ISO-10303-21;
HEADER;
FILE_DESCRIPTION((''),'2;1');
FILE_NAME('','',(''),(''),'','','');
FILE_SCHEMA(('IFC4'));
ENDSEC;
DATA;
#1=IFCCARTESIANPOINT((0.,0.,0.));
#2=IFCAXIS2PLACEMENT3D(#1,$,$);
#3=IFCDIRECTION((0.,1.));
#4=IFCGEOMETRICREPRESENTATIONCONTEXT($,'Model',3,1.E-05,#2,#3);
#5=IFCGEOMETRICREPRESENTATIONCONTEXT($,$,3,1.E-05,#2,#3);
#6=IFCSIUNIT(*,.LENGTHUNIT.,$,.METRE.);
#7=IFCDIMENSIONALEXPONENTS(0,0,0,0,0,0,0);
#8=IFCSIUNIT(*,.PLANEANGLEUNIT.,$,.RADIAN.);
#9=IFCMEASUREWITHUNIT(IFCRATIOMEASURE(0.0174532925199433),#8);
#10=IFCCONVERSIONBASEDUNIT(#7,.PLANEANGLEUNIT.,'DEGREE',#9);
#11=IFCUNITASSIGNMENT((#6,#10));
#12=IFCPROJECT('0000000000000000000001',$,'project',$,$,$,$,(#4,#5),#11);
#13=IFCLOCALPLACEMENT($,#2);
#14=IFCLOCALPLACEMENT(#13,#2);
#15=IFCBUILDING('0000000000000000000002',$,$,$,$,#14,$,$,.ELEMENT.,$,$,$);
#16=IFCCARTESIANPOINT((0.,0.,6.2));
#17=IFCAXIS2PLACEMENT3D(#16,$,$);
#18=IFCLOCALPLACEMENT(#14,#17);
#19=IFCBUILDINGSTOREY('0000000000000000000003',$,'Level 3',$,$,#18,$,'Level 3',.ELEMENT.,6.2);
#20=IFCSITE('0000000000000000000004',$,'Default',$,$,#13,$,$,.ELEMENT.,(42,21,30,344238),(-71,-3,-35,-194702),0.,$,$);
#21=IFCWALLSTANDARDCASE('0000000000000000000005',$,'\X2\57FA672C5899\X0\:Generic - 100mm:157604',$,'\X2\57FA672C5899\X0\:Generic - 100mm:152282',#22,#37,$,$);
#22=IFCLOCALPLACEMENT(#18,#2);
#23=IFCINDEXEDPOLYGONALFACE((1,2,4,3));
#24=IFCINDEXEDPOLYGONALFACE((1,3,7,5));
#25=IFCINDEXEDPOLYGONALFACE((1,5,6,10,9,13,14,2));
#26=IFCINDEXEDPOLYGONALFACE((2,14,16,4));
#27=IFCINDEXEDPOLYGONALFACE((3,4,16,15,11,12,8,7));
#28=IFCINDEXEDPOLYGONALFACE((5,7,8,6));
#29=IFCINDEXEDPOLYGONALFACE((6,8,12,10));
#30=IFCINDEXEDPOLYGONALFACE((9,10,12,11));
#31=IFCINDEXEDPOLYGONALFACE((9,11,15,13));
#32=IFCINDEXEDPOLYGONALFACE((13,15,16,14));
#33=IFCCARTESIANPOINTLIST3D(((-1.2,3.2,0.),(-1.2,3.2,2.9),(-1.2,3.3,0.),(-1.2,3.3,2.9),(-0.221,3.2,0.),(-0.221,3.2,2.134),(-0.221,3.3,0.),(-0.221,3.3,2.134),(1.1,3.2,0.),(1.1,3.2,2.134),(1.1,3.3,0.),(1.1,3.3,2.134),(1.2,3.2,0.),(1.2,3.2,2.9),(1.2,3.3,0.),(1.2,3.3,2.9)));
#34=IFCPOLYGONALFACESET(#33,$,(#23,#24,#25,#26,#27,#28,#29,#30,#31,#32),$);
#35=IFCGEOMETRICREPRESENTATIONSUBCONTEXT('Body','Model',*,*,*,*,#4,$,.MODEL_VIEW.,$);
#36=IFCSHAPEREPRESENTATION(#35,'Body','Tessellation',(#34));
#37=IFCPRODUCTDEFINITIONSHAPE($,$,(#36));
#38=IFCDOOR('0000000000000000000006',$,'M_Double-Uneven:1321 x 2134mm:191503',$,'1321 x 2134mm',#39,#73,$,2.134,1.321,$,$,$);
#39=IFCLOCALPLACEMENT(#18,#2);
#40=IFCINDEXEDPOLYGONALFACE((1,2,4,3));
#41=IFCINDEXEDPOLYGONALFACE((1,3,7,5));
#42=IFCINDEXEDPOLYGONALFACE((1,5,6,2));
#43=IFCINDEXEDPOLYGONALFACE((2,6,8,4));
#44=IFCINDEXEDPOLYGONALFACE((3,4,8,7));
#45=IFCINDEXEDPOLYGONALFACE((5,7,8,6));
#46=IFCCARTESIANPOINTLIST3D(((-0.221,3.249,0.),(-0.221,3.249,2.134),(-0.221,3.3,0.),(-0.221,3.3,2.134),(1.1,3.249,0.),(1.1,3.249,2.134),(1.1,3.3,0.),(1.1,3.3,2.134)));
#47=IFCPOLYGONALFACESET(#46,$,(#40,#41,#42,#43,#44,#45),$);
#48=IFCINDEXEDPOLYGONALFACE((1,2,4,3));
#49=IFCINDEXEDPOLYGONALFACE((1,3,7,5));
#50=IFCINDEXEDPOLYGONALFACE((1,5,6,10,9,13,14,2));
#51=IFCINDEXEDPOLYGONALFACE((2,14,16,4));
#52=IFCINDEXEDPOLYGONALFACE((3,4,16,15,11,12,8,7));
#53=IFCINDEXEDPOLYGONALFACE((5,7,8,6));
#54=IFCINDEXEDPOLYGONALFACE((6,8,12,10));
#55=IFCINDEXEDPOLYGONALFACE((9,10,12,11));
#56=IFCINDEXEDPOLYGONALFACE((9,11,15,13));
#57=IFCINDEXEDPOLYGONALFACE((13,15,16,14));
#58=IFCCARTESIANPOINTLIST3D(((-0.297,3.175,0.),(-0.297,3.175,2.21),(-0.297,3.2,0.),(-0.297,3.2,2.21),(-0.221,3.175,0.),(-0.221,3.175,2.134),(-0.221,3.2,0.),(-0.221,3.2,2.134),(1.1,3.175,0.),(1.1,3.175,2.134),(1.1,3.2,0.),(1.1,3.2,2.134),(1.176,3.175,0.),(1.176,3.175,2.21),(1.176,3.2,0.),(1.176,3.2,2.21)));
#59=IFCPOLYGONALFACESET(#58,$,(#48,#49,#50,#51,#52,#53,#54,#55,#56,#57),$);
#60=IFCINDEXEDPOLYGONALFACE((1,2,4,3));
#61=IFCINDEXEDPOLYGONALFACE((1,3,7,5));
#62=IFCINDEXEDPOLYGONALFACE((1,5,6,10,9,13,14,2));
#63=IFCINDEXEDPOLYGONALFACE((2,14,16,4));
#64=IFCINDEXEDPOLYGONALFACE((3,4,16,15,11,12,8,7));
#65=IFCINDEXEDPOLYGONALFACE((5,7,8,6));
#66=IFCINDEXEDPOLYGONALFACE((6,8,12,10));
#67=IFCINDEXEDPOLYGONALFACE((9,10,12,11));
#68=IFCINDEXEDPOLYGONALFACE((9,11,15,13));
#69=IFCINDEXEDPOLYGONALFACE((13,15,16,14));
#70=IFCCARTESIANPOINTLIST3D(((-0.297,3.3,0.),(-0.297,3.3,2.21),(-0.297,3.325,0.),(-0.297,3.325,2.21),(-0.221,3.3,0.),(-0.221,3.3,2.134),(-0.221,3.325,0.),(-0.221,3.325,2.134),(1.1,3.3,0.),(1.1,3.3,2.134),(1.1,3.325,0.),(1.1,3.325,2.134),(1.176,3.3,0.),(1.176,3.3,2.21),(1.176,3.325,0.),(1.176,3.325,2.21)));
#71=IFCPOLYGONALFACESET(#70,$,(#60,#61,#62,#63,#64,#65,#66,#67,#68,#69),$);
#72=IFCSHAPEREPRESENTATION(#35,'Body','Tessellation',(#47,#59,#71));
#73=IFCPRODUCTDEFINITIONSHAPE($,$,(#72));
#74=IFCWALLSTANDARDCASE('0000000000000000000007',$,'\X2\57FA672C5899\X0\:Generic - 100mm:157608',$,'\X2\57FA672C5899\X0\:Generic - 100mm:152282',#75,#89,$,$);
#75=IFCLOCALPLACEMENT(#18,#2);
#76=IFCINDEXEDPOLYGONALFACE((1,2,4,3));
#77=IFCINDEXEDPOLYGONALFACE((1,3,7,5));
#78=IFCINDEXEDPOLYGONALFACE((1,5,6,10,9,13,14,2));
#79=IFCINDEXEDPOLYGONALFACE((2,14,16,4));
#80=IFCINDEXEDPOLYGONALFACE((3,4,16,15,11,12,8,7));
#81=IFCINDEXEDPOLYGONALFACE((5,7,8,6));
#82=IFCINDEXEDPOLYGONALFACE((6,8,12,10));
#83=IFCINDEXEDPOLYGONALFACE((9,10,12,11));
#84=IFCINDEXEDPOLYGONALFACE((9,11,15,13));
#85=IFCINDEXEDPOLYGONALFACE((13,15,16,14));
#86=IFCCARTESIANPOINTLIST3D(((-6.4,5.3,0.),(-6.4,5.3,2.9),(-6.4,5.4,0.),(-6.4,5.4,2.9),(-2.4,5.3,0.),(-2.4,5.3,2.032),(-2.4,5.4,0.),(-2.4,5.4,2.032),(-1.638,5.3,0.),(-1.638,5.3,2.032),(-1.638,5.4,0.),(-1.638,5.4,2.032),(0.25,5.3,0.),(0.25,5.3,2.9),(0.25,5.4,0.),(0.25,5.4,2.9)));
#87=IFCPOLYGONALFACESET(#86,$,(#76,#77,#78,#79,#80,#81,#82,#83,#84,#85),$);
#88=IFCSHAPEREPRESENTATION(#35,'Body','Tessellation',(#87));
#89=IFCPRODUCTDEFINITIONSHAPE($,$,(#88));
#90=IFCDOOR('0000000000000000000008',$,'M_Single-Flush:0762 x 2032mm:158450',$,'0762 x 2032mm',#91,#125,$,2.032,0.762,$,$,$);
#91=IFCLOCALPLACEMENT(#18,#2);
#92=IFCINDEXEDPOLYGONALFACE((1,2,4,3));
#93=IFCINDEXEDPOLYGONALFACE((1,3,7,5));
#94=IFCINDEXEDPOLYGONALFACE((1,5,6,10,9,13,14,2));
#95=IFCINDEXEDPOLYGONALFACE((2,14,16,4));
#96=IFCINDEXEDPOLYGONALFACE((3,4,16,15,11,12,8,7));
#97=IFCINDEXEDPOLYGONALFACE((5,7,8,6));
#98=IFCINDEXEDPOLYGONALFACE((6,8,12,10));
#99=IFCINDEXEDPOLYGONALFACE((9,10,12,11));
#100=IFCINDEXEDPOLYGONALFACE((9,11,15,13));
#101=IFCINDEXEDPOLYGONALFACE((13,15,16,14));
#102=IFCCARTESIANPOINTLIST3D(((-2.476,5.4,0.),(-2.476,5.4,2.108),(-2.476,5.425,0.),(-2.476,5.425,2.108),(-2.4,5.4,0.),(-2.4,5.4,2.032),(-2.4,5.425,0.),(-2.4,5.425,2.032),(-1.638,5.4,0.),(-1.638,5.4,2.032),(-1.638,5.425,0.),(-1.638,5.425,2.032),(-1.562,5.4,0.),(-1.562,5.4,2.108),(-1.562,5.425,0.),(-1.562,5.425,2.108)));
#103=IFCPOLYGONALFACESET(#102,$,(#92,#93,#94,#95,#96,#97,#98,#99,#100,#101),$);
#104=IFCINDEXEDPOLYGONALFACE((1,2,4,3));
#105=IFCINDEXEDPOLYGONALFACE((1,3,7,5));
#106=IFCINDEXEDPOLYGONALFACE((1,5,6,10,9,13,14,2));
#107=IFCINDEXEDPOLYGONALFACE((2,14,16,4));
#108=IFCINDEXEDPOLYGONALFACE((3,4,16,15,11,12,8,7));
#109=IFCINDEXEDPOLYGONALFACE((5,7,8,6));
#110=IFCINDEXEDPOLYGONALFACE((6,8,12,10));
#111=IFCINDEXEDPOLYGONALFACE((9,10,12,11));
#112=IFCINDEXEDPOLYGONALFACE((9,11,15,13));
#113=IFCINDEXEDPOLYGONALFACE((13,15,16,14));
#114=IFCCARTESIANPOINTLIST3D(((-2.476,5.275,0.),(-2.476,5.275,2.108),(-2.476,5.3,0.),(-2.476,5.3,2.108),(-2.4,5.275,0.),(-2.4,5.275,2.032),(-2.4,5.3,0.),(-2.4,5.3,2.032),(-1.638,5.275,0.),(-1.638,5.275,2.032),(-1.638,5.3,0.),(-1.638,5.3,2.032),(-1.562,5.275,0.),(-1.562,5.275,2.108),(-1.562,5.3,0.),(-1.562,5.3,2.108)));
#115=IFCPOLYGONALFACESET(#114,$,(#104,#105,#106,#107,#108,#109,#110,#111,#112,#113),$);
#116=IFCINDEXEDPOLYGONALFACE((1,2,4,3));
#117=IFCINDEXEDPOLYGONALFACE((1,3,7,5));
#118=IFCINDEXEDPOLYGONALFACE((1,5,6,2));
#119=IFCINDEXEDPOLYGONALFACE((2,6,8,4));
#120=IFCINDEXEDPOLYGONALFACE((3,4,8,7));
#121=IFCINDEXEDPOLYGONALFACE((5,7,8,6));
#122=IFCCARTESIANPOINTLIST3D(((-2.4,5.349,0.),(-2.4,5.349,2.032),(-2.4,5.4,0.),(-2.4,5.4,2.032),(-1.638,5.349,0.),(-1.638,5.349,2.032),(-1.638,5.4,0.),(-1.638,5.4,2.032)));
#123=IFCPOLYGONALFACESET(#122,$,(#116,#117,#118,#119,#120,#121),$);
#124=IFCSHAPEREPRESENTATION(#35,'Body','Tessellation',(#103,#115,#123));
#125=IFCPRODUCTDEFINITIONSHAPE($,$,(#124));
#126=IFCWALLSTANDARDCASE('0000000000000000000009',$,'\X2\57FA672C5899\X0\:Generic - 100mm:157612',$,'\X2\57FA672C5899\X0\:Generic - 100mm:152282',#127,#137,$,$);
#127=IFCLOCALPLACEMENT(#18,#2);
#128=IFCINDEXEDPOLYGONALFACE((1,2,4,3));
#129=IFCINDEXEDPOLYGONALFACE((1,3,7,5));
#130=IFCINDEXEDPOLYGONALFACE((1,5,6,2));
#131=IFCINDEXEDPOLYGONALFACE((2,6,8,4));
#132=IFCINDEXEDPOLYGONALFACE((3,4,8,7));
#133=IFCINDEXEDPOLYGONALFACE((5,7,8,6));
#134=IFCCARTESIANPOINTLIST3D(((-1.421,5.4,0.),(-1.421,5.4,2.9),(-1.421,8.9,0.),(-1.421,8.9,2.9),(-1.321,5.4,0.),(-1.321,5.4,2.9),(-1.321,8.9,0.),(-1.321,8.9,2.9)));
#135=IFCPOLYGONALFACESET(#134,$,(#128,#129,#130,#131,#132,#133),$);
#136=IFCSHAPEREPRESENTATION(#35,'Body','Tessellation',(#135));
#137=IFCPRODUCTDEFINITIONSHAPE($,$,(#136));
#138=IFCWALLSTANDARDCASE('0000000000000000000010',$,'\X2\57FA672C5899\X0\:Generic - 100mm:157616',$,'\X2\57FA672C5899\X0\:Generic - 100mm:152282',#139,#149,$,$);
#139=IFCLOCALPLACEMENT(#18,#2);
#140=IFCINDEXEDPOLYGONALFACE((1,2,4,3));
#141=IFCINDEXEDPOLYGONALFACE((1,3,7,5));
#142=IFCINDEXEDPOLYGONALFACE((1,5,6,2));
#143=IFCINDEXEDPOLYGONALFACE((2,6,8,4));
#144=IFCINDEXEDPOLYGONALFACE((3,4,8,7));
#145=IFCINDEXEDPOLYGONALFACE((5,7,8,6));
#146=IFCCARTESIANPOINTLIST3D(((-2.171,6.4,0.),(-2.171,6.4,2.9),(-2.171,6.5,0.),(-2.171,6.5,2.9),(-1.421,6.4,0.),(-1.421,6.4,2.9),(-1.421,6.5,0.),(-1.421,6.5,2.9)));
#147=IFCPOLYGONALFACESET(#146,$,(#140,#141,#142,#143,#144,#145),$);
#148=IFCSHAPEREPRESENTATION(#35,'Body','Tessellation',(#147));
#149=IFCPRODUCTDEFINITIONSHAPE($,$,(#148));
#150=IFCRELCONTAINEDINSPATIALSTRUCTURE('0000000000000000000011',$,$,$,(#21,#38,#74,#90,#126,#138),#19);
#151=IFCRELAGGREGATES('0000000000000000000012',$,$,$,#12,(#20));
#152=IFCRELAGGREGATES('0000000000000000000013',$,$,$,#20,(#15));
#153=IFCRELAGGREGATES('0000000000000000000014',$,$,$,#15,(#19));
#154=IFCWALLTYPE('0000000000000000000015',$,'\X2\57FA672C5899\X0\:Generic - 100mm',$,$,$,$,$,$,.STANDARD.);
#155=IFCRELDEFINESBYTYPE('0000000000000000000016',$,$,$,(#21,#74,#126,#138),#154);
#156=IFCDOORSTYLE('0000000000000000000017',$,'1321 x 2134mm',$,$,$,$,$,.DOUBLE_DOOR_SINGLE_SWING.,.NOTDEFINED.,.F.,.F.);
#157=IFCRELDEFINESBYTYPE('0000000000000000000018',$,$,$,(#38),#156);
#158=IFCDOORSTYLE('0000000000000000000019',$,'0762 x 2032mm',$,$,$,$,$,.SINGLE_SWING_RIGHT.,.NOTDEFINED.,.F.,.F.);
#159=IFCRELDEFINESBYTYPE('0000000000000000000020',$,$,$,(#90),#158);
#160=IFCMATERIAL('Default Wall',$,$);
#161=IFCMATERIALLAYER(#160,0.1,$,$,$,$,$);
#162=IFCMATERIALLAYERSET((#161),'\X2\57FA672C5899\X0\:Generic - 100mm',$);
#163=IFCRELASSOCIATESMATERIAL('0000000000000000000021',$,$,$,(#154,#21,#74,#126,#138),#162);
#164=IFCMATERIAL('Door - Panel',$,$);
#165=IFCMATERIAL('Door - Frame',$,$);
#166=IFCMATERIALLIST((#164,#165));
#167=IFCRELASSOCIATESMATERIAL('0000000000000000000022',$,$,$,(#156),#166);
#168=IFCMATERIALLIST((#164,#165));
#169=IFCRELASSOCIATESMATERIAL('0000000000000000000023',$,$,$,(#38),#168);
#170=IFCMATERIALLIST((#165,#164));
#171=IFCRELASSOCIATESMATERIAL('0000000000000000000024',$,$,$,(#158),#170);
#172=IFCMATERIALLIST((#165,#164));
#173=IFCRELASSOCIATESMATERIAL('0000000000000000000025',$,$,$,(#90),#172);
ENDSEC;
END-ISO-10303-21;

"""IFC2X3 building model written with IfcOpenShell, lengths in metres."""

from ifc_helpers import new_model, entity, si_unit, converted_unit, direction, frame, frame_2d, origin, origin_2d_with_axis, place, context, subcontext, project, spatial, polyline, rectangle, outline, extrude, clip, bounded_halfspace, source, transform, mapped, material, material_list, layer, layer_set, layer_usage, type_object, type_shapes, element, fill, save


model = new_model("IFC2X3")

# Units and contexts
model_context = context("Model", 3, precision=1e-05, world=origin(), true_north=direction((0.0, 1.0)))
context_of_model = context(None, 3, precision=1e-05, world=origin(), true_north=direction((0.0, 1.0)))
body_context = subcontext(model_context, "Body", "Model", "MODEL_VIEW")
ifc_project = project(units=[si_unit("LENGTHUNIT", "METRE"), converted_unit("PLANEANGLEUNIT", "DEGREE", entity("IfcRatioMeasure", 0.0174532925199433), si_unit("PLANEANGLEUNIT", "RADIAN"), dimensions=[0, 0, 0, 0, 0, 0, 0])], contexts=[model_context, context_of_model])

# Site, building, storey
site_placement = place(None, origin())
site = spatial("IfcSite", under=ifc_project, at=site_placement, Name="Default", CompositionType="ELEMENT", RefLatitude=(42, 21, 30, 344238), RefLongitude=(-71, -3, -35, -194702), RefElevation=0.0)
building_placement = place(site_placement, origin())
building = spatial("IfcBuilding", under=site, at=building_placement, CompositionType="ELEMENT")
storey_placement = place(building_placement, frame((0.0, 0.0, 6.2)))
storey = spatial("IfcBuildingStorey", under=building, at=storey_placement, Name="Level 3", LongName="Level 3", CompositionType="ELEMENT", Elevation=6.2)

# Shared definitions
ifc_material_1 = material(Name="Default Wall")

# Shared definitions
ifc_material_2 = material(Name="Door - Panel")
ifc_material_3 = material(Name="Door - Frame")

# Shared definitions
ifc_layer_1 = layer(ifc_material_1, 0.1)
ifc_layer_set_1 = layer_set([ifc_layer_1], Name="基本墙:Generic - 100mm")
wall_type_1 = type_object("IfcWallType", Name="基本墙:Generic - 100mm", PredefinedType="STANDARD", material=ifc_layer_set_1)

# Walls, openings, doors
ifc_layer_usage_1 = layer_usage(ifc_layer_set_1, "AXIS2", "NEGATIVE", 0.05)
wall_1_placement = place(storey_placement, frame((-1.2, 3.25, 0.0)))
wall_1 = element("IfcWallStandardCase", 1, at=wall_1_placement, inside=storey, type_object=wall_type_1, material=ifc_layer_usage_1, Name="基本墙:Generic - 100mm:157604", ObjectType="基本墙:Generic - 100mm:152282", context=body_context, shape_type="Clipping", body=[
    clip(extrude(rectangle(XDim=2.4, YDim=0.1, at=frame_2d((1.2, 0.0), x_axis=(-1.0, 0.0))), origin(), (0.0, 0.0, 1.0), 3.2), bounded_halfspace(frame((0.0, -0.05, 2.9), z_axis=(0.0, 0.0, -1.0), x_axis=(0.0, -1.0, 0.0)), True, frame((0.0, -0.05, 2.9), z_axis=(0.0, 0.0, -1.0), x_axis=(0.0, -1.0, 0.0)), polyline([(0.0, 0.0), (-0.1, 0.0), (-0.1, -2.4), (0.0, -2.4), (0.0, 0.0)]))),
])
opening_1_placement = place(wall_1_placement, frame((0.979, -0.05, 0.0)))
opening_1 = element("IfcOpeningElement", 2, at=opening_1_placement, cuts=wall_1, ObjectType="Opening", context=body_context, shape_type="SweptSolid", body=[
    extrude(rectangle(XDim=2.134, YDim=1.321, at=frame_2d((1.067, 0.6605), x_axis=(1.0, 0.0))), frame((0.0, 0.0, 0.0), z_axis=(0.0, 1.0, 0.0), x_axis=(0.0, 0.0, 1.0)), (0.0, 0.0, 1.0), 0.1),
])
ifc_material_list_1 = material_list([ifc_material_2, ifc_material_3])
ifc_material_list_2 = material_list([ifc_material_2, ifc_material_3])
door_style_1 = type_object("IfcDoorStyle", Name="1321 x 2134mm", ConstructionType="NOTDEFINED", OperationType="DOUBLE_DOOR_SINGLE_SWING", ParameterTakesPrecedence=False, Sizeable=False, material=ifc_material_list_2)
shared_shape_1 = source(origin(), body_context, "Body", "SweptSolid", [
    extrude(rectangle(XDim=0.051, YDim=1.321, at=origin_2d_with_axis()), frame((1.7775, 0.0745, 0.0), z_axis=(0.0, 0.0, 1.0), x_axis=(0.0, -1.0, 0.0)), (0.0, 0.0, 1.0), 2.134),
    extrude(outline(polyline([(-1.048, 0.6605), (1.086, 0.6605), (1.086, 0.7365), (-1.124, 0.7365), (-1.124, -0.7365), (1.086, -0.7365), (1.086, -0.6605), (-1.048, -0.6605), (-1.048, 0.6605)])), frame((1.7775, 0.0, 1.086), z_axis=(0.0, -1.0, 0.0), x_axis=(0.0, 0.0, -1.0)), (0.0, 0.0, 1.0), 0.025),
    extrude(outline(polyline([(-1.048, 0.6605), (1.086, 0.6605), (1.086, 0.7365), (-1.124, 0.7365), (-1.124, -0.7365), (1.086, -0.7365), (1.086, -0.6605), (-1.048, -0.6605), (-1.048, 0.6605)])), frame((1.7775, 0.125, 1.086), z_axis=(0.0, -1.0, 0.0), x_axis=(0.0, 0.0, -1.0)), (0.0, 0.0, 1.0), 0.025),
])
type_shapes(door_style_1, [shared_shape_1])
door_1_placement = place(opening_1_placement, frame((-1.117, 0.0, 0.0)))
door_1 = element("IfcDoor", 3, at=door_1_placement, inside=storey, type_object=door_style_1, material=ifc_material_list_1, Name="M_Double-Uneven:1321 x 2134mm:191503", ObjectType="1321 x 2134mm", OverallHeight=2.134, OverallWidth=1.321, context=body_context, shape_type="MappedRepresentation", body=[
    mapped(shared_shape_1, transform((0.0, 0.0, 0.0), scale=1.0)),
])
fill(opening_1, door_1)
ifc_layer_usage_2 = layer_usage(ifc_layer_set_1, "AXIS2", "NEGATIVE", 0.05)
wall_2_placement = place(storey_placement, frame((-6.4, 5.35, 0.0)))
wall_2 = element("IfcWallStandardCase", 4, at=wall_2_placement, inside=storey, type_object=wall_type_1, material=ifc_layer_usage_2, Name="基本墙:Generic - 100mm:157608", ObjectType="基本墙:Generic - 100mm:152282", context=body_context, shape_type="Clipping", body=[
    clip(extrude(rectangle(XDim=6.65, YDim=0.1, at=frame_2d((3.325, 0.0), x_axis=(-1.0, 0.0))), origin(), (0.0, 0.0, 1.0), 3.2), bounded_halfspace(frame((0.0, -0.05, 2.9), z_axis=(0.0, 0.0, -1.0), x_axis=(0.0, -1.0, 0.0)), True, frame((0.0, -0.05, 2.9), z_axis=(0.0, 0.0, -1.0), x_axis=(0.0, -1.0, 0.0)), polyline([(0.0, 0.0), (-0.1, 0.0), (-0.1, -6.55), (-0.1, -6.65), (0.0, -6.65), (0.0, 0.0)]))),
])
opening_2_placement = place(wall_2_placement, frame((4.0, -0.05, 0.0)))
opening_2 = element("IfcOpeningElement", 5, at=opening_2_placement, cuts=wall_2, ObjectType="Opening", context=body_context, shape_type="SweptSolid", body=[
    extrude(rectangle(XDim=0.762, YDim=2.032, at=frame_2d((1.016, 0.381), x_axis=(0.0, 1.0))), frame((0.0, 0.0, 0.0), z_axis=(0.0, 1.0, 0.0), x_axis=(0.0, 0.0, 1.0)), (0.0, 0.0, 1.0), 0.1),
])
ifc_material_list_3 = material_list([ifc_material_3, ifc_material_2])
ifc_material_list_4 = material_list([ifc_material_3, ifc_material_2])
door_style_2 = type_object("IfcDoorStyle", Name="0762 x 2032mm", ConstructionType="NOTDEFINED", OperationType="SINGLE_SWING_RIGHT", ParameterTakesPrecedence=False, Sizeable=False, material=ifc_material_list_4)
shared_shape_2 = source(origin(), body_context, "Body", "SweptSolid", [
    extrude(outline(polyline([(-0.457, -1.073), (0.457, -1.073), (0.457, 1.035), (0.381, 1.035), (0.381, -0.997), (-0.381, -0.997), (-0.381, 1.035), (-0.457, 1.035), (-0.457, -1.073)])), frame((0.381, 0.1, 1.035), z_axis=(0.0, 1.0, 0.0), x_axis=(1.0, 0.0, 0.0)), (0.0, 0.0, 1.0), 0.025),
    extrude(outline(polyline([(-1.073, -0.457), (1.035, -0.457), (1.035, -0.381), (-0.997, -0.381), (-0.997, 0.381), (1.035, 0.381), (1.035, 0.457), (-1.073, 0.457), (-1.073, -0.457)])), frame((0.381, -0.025, 1.035), z_axis=(0.0, 1.0, 0.0), x_axis=(0.0, 0.0, -1.0)), (0.0, 0.0, 1.0), 0.025),
    extrude(rectangle(XDim=0.051, YDim=0.762, at=origin_2d_with_axis()), frame((0.381, 0.0745, 0.0), z_axis=(0.0, 0.0, 1.0), x_axis=(0.0, 1.0, 0.0)), (0.0, 0.0, 1.0), 2.032),
])
type_shapes(door_style_2, [shared_shape_2])
door_2_placement = place(opening_2_placement, origin())
door_2 = element("IfcDoor", 6, at=door_2_placement, inside=storey, type_object=door_style_2, material=ifc_material_list_3, Name="M_Single-Flush:0762 x 2032mm:158450", ObjectType="0762 x 2032mm", OverallHeight=2.032, OverallWidth=0.762, context=body_context, shape_type="MappedRepresentation", body=[
    mapped(shared_shape_2, transform((0.0, 0.0, 0.0), scale=1.0)),
])
fill(opening_2, door_2)

# Walls
ifc_layer_usage_3 = layer_usage(ifc_layer_set_1, "AXIS2", "NEGATIVE", 0.05)
wall_3_placement = place(storey_placement, frame((-1.371, 5.4, 0.0), z_axis=(0.0, 0.0, 1.0), x_axis=(0.0, 1.0, 0.0)))
element("IfcWallStandardCase", 7, at=wall_3_placement, inside=storey, type_object=wall_type_1, material=ifc_layer_usage_3, Name="基本墙:Generic - 100mm:157612", ObjectType="基本墙:Generic - 100mm:152282", context=body_context, shape_type="Clipping", body=[
    clip(extrude(rectangle(XDim=3.5, YDim=0.1, at=frame_2d((1.75, 0.0), x_axis=(-1.0, 0.0))), origin(), (0.0, 0.0, 1.0), 3.2), bounded_halfspace(frame((0.0, -0.05, 2.9), z_axis=(0.0, 0.0, -1.0), x_axis=(-1.0, 0.0, 0.0)), True, frame((0.0, -0.05, 2.9), z_axis=(0.0, 0.0, -1.0), x_axis=(-1.0, 0.0, 0.0)), polyline([(0.0, 0.0), (0.0, 0.1), (-3.5, 0.1), (-3.5, 0.0), (-1.4, 0.0), (-1.3, 0.0), (0.0, 0.0)]))),
])
ifc_layer_usage_4 = layer_usage(ifc_layer_set_1, "AXIS2", "NEGATIVE", 0.05)
wall_4_placement = place(storey_placement, frame((-2.171, 6.45, 0.0)))
element("IfcWallStandardCase", 8, at=wall_4_placement, inside=storey, type_object=wall_type_1, material=ifc_layer_usage_4, Name="基本墙:Generic - 100mm:157616", ObjectType="基本墙:Generic - 100mm:152282", context=body_context, shape_type="Clipping", body=[
    clip(extrude(rectangle(XDim=0.75, YDim=0.1, at=frame_2d((0.375, 0.0), x_axis=(-1.0, 0.0))), origin(), (0.0, 0.0, 1.0), 3.2), bounded_halfspace(frame((0.0, -0.05, 2.9), z_axis=(0.0, 0.0, -1.0), x_axis=(0.0, -1.0, 0.0)), True, frame((0.0, -0.05, 2.9), z_axis=(0.0, 0.0, -1.0), x_axis=(0.0, -1.0, 0.0)), polyline([(0.0, 0.0), (-0.1, 0.0), (-0.1, -0.75), (0.0, -0.75), (0.0, 0.0)]))),
])

save(model, "model.ifc")
